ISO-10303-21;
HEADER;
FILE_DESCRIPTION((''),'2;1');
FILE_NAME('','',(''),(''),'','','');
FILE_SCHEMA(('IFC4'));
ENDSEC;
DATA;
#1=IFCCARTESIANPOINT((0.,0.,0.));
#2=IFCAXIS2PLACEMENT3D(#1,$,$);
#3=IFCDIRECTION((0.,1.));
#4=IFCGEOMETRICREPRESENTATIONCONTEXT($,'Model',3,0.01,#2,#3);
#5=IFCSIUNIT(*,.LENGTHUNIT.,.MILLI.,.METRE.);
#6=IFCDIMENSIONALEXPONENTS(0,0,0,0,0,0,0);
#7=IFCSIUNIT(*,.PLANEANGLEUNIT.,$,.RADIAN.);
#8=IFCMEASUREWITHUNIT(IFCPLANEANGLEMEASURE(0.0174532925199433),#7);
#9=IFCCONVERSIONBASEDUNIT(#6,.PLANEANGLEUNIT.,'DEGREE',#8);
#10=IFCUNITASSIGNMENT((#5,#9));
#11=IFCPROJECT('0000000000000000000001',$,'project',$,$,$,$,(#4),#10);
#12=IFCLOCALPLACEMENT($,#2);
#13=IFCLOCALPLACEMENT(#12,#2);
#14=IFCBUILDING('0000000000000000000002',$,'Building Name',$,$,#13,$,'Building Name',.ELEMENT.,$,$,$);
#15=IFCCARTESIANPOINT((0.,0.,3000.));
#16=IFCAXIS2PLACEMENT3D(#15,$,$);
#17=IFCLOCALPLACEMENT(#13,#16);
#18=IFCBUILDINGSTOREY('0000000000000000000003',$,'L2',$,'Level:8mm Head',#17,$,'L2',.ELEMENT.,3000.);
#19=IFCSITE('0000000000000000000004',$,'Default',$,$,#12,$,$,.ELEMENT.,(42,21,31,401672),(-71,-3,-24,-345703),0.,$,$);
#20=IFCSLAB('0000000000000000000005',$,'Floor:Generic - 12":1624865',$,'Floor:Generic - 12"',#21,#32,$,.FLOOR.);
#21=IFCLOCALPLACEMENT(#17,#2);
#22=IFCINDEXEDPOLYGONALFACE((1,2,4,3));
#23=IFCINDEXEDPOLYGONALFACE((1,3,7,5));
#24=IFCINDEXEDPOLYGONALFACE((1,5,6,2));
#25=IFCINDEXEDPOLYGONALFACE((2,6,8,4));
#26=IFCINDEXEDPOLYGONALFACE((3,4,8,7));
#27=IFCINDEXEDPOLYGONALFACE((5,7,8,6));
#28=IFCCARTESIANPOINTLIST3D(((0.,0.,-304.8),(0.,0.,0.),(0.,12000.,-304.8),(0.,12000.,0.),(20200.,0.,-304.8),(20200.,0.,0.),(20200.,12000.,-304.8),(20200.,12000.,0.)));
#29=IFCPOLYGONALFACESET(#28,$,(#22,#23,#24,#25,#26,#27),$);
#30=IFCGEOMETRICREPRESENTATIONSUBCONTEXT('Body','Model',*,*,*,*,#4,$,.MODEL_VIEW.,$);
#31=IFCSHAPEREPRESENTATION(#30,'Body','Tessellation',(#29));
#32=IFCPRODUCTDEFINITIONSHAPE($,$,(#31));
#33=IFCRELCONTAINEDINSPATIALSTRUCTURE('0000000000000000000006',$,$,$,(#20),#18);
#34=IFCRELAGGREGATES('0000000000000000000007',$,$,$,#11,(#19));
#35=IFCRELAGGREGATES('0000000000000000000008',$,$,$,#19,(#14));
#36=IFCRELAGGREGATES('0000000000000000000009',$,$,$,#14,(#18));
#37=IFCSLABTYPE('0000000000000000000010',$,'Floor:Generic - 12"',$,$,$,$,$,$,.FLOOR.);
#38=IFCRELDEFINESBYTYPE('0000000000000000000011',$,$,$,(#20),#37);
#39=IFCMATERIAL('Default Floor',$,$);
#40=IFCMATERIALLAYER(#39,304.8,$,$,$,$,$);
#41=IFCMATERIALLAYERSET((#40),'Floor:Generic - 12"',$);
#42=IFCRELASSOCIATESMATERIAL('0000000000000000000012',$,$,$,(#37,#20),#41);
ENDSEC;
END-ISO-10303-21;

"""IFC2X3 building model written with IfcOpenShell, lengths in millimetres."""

from ifc_helpers import new_model, entity, si_unit, converted_unit, direction, frame, origin, origin_2d_with_axis, place, context, subcontext, project, spatial, rectangle, extrude, material, layer, layer_set, layer_usage, type_object, element, save


model = new_model("IFC2X3")

# Units and contexts
model_context = context("Model", 3, precision=0.01, world=origin(), true_north=direction((0.0, 1.0)))
body_context = subcontext(model_context, "Body", "Model", "MODEL_VIEW")
ifc_project = project(units=[si_unit("LENGTHUNIT", "METRE", prefix="MILLI"), converted_unit("PLANEANGLEUNIT", "DEGREE", entity("IfcPlaneAngleMeasure", 0.0174532925199433), si_unit("PLANEANGLEUNIT", "RADIAN"), dimensions=[0, 0, 0, 0, 0, 0, 0])], contexts=[model_context])

# Site, building, storey
site_placement = place(None, origin())
site = spatial("IfcSite", under=ifc_project, at=site_placement, Name="Default", CompositionType="ELEMENT", RefLatitude=(42, 21, 31, 401672), RefLongitude=(-71, -3, -24, -345703), RefElevation=0.0)
building_placement = place(site_placement, origin())
building = spatial("IfcBuilding", under=site, at=building_placement, Name="Building Name", LongName="Building Name", CompositionType="ELEMENT")
storey_placement = place(building_placement, frame((0.0, 0.0, 3000.0)))
storey = spatial("IfcBuildingStorey", under=building, at=storey_placement, Name="L2", ObjectType="Level:8mm Head", LongName="L2", CompositionType="ELEMENT", Elevation=3000.0)

# Slab
ifc_material = material(Name="Default Floor")
ifc_layer = layer(ifc_material, 304.8)
ifc_layer_set = layer_set([ifc_layer], Name="Floor:Generic - 12\"")
ifc_layer_usage = layer_usage(ifc_layer_set, "AXIS3", "POSITIVE", 0.0)
slab_type = type_object("IfcSlabType", Name="Floor:Generic - 12\"", PredefinedType="FLOOR", material=ifc_layer_set)
slab_placement = place(storey_placement, origin())
element("IfcSlab", 1, at=slab_placement, inside=storey, type_object=slab_type, material=ifc_layer_usage, Name="Floor:Generic - 12\":1624865", ObjectType="Floor:Generic - 12\"", PredefinedType="FLOOR", context=body_context, shape_type="SweptSolid", body=[
    extrude(rectangle(XDim=12000.0, YDim=20200.0, at=origin_2d_with_axis()), frame((10100.0, 6000.0, 0.0), z_axis=(0.0, 0.0, -1.0), x_axis=(0.0, 1.0, 0.0)), (0.0, 0.0, 1.0), 304.8),
])

save(model, "model.ifc")
